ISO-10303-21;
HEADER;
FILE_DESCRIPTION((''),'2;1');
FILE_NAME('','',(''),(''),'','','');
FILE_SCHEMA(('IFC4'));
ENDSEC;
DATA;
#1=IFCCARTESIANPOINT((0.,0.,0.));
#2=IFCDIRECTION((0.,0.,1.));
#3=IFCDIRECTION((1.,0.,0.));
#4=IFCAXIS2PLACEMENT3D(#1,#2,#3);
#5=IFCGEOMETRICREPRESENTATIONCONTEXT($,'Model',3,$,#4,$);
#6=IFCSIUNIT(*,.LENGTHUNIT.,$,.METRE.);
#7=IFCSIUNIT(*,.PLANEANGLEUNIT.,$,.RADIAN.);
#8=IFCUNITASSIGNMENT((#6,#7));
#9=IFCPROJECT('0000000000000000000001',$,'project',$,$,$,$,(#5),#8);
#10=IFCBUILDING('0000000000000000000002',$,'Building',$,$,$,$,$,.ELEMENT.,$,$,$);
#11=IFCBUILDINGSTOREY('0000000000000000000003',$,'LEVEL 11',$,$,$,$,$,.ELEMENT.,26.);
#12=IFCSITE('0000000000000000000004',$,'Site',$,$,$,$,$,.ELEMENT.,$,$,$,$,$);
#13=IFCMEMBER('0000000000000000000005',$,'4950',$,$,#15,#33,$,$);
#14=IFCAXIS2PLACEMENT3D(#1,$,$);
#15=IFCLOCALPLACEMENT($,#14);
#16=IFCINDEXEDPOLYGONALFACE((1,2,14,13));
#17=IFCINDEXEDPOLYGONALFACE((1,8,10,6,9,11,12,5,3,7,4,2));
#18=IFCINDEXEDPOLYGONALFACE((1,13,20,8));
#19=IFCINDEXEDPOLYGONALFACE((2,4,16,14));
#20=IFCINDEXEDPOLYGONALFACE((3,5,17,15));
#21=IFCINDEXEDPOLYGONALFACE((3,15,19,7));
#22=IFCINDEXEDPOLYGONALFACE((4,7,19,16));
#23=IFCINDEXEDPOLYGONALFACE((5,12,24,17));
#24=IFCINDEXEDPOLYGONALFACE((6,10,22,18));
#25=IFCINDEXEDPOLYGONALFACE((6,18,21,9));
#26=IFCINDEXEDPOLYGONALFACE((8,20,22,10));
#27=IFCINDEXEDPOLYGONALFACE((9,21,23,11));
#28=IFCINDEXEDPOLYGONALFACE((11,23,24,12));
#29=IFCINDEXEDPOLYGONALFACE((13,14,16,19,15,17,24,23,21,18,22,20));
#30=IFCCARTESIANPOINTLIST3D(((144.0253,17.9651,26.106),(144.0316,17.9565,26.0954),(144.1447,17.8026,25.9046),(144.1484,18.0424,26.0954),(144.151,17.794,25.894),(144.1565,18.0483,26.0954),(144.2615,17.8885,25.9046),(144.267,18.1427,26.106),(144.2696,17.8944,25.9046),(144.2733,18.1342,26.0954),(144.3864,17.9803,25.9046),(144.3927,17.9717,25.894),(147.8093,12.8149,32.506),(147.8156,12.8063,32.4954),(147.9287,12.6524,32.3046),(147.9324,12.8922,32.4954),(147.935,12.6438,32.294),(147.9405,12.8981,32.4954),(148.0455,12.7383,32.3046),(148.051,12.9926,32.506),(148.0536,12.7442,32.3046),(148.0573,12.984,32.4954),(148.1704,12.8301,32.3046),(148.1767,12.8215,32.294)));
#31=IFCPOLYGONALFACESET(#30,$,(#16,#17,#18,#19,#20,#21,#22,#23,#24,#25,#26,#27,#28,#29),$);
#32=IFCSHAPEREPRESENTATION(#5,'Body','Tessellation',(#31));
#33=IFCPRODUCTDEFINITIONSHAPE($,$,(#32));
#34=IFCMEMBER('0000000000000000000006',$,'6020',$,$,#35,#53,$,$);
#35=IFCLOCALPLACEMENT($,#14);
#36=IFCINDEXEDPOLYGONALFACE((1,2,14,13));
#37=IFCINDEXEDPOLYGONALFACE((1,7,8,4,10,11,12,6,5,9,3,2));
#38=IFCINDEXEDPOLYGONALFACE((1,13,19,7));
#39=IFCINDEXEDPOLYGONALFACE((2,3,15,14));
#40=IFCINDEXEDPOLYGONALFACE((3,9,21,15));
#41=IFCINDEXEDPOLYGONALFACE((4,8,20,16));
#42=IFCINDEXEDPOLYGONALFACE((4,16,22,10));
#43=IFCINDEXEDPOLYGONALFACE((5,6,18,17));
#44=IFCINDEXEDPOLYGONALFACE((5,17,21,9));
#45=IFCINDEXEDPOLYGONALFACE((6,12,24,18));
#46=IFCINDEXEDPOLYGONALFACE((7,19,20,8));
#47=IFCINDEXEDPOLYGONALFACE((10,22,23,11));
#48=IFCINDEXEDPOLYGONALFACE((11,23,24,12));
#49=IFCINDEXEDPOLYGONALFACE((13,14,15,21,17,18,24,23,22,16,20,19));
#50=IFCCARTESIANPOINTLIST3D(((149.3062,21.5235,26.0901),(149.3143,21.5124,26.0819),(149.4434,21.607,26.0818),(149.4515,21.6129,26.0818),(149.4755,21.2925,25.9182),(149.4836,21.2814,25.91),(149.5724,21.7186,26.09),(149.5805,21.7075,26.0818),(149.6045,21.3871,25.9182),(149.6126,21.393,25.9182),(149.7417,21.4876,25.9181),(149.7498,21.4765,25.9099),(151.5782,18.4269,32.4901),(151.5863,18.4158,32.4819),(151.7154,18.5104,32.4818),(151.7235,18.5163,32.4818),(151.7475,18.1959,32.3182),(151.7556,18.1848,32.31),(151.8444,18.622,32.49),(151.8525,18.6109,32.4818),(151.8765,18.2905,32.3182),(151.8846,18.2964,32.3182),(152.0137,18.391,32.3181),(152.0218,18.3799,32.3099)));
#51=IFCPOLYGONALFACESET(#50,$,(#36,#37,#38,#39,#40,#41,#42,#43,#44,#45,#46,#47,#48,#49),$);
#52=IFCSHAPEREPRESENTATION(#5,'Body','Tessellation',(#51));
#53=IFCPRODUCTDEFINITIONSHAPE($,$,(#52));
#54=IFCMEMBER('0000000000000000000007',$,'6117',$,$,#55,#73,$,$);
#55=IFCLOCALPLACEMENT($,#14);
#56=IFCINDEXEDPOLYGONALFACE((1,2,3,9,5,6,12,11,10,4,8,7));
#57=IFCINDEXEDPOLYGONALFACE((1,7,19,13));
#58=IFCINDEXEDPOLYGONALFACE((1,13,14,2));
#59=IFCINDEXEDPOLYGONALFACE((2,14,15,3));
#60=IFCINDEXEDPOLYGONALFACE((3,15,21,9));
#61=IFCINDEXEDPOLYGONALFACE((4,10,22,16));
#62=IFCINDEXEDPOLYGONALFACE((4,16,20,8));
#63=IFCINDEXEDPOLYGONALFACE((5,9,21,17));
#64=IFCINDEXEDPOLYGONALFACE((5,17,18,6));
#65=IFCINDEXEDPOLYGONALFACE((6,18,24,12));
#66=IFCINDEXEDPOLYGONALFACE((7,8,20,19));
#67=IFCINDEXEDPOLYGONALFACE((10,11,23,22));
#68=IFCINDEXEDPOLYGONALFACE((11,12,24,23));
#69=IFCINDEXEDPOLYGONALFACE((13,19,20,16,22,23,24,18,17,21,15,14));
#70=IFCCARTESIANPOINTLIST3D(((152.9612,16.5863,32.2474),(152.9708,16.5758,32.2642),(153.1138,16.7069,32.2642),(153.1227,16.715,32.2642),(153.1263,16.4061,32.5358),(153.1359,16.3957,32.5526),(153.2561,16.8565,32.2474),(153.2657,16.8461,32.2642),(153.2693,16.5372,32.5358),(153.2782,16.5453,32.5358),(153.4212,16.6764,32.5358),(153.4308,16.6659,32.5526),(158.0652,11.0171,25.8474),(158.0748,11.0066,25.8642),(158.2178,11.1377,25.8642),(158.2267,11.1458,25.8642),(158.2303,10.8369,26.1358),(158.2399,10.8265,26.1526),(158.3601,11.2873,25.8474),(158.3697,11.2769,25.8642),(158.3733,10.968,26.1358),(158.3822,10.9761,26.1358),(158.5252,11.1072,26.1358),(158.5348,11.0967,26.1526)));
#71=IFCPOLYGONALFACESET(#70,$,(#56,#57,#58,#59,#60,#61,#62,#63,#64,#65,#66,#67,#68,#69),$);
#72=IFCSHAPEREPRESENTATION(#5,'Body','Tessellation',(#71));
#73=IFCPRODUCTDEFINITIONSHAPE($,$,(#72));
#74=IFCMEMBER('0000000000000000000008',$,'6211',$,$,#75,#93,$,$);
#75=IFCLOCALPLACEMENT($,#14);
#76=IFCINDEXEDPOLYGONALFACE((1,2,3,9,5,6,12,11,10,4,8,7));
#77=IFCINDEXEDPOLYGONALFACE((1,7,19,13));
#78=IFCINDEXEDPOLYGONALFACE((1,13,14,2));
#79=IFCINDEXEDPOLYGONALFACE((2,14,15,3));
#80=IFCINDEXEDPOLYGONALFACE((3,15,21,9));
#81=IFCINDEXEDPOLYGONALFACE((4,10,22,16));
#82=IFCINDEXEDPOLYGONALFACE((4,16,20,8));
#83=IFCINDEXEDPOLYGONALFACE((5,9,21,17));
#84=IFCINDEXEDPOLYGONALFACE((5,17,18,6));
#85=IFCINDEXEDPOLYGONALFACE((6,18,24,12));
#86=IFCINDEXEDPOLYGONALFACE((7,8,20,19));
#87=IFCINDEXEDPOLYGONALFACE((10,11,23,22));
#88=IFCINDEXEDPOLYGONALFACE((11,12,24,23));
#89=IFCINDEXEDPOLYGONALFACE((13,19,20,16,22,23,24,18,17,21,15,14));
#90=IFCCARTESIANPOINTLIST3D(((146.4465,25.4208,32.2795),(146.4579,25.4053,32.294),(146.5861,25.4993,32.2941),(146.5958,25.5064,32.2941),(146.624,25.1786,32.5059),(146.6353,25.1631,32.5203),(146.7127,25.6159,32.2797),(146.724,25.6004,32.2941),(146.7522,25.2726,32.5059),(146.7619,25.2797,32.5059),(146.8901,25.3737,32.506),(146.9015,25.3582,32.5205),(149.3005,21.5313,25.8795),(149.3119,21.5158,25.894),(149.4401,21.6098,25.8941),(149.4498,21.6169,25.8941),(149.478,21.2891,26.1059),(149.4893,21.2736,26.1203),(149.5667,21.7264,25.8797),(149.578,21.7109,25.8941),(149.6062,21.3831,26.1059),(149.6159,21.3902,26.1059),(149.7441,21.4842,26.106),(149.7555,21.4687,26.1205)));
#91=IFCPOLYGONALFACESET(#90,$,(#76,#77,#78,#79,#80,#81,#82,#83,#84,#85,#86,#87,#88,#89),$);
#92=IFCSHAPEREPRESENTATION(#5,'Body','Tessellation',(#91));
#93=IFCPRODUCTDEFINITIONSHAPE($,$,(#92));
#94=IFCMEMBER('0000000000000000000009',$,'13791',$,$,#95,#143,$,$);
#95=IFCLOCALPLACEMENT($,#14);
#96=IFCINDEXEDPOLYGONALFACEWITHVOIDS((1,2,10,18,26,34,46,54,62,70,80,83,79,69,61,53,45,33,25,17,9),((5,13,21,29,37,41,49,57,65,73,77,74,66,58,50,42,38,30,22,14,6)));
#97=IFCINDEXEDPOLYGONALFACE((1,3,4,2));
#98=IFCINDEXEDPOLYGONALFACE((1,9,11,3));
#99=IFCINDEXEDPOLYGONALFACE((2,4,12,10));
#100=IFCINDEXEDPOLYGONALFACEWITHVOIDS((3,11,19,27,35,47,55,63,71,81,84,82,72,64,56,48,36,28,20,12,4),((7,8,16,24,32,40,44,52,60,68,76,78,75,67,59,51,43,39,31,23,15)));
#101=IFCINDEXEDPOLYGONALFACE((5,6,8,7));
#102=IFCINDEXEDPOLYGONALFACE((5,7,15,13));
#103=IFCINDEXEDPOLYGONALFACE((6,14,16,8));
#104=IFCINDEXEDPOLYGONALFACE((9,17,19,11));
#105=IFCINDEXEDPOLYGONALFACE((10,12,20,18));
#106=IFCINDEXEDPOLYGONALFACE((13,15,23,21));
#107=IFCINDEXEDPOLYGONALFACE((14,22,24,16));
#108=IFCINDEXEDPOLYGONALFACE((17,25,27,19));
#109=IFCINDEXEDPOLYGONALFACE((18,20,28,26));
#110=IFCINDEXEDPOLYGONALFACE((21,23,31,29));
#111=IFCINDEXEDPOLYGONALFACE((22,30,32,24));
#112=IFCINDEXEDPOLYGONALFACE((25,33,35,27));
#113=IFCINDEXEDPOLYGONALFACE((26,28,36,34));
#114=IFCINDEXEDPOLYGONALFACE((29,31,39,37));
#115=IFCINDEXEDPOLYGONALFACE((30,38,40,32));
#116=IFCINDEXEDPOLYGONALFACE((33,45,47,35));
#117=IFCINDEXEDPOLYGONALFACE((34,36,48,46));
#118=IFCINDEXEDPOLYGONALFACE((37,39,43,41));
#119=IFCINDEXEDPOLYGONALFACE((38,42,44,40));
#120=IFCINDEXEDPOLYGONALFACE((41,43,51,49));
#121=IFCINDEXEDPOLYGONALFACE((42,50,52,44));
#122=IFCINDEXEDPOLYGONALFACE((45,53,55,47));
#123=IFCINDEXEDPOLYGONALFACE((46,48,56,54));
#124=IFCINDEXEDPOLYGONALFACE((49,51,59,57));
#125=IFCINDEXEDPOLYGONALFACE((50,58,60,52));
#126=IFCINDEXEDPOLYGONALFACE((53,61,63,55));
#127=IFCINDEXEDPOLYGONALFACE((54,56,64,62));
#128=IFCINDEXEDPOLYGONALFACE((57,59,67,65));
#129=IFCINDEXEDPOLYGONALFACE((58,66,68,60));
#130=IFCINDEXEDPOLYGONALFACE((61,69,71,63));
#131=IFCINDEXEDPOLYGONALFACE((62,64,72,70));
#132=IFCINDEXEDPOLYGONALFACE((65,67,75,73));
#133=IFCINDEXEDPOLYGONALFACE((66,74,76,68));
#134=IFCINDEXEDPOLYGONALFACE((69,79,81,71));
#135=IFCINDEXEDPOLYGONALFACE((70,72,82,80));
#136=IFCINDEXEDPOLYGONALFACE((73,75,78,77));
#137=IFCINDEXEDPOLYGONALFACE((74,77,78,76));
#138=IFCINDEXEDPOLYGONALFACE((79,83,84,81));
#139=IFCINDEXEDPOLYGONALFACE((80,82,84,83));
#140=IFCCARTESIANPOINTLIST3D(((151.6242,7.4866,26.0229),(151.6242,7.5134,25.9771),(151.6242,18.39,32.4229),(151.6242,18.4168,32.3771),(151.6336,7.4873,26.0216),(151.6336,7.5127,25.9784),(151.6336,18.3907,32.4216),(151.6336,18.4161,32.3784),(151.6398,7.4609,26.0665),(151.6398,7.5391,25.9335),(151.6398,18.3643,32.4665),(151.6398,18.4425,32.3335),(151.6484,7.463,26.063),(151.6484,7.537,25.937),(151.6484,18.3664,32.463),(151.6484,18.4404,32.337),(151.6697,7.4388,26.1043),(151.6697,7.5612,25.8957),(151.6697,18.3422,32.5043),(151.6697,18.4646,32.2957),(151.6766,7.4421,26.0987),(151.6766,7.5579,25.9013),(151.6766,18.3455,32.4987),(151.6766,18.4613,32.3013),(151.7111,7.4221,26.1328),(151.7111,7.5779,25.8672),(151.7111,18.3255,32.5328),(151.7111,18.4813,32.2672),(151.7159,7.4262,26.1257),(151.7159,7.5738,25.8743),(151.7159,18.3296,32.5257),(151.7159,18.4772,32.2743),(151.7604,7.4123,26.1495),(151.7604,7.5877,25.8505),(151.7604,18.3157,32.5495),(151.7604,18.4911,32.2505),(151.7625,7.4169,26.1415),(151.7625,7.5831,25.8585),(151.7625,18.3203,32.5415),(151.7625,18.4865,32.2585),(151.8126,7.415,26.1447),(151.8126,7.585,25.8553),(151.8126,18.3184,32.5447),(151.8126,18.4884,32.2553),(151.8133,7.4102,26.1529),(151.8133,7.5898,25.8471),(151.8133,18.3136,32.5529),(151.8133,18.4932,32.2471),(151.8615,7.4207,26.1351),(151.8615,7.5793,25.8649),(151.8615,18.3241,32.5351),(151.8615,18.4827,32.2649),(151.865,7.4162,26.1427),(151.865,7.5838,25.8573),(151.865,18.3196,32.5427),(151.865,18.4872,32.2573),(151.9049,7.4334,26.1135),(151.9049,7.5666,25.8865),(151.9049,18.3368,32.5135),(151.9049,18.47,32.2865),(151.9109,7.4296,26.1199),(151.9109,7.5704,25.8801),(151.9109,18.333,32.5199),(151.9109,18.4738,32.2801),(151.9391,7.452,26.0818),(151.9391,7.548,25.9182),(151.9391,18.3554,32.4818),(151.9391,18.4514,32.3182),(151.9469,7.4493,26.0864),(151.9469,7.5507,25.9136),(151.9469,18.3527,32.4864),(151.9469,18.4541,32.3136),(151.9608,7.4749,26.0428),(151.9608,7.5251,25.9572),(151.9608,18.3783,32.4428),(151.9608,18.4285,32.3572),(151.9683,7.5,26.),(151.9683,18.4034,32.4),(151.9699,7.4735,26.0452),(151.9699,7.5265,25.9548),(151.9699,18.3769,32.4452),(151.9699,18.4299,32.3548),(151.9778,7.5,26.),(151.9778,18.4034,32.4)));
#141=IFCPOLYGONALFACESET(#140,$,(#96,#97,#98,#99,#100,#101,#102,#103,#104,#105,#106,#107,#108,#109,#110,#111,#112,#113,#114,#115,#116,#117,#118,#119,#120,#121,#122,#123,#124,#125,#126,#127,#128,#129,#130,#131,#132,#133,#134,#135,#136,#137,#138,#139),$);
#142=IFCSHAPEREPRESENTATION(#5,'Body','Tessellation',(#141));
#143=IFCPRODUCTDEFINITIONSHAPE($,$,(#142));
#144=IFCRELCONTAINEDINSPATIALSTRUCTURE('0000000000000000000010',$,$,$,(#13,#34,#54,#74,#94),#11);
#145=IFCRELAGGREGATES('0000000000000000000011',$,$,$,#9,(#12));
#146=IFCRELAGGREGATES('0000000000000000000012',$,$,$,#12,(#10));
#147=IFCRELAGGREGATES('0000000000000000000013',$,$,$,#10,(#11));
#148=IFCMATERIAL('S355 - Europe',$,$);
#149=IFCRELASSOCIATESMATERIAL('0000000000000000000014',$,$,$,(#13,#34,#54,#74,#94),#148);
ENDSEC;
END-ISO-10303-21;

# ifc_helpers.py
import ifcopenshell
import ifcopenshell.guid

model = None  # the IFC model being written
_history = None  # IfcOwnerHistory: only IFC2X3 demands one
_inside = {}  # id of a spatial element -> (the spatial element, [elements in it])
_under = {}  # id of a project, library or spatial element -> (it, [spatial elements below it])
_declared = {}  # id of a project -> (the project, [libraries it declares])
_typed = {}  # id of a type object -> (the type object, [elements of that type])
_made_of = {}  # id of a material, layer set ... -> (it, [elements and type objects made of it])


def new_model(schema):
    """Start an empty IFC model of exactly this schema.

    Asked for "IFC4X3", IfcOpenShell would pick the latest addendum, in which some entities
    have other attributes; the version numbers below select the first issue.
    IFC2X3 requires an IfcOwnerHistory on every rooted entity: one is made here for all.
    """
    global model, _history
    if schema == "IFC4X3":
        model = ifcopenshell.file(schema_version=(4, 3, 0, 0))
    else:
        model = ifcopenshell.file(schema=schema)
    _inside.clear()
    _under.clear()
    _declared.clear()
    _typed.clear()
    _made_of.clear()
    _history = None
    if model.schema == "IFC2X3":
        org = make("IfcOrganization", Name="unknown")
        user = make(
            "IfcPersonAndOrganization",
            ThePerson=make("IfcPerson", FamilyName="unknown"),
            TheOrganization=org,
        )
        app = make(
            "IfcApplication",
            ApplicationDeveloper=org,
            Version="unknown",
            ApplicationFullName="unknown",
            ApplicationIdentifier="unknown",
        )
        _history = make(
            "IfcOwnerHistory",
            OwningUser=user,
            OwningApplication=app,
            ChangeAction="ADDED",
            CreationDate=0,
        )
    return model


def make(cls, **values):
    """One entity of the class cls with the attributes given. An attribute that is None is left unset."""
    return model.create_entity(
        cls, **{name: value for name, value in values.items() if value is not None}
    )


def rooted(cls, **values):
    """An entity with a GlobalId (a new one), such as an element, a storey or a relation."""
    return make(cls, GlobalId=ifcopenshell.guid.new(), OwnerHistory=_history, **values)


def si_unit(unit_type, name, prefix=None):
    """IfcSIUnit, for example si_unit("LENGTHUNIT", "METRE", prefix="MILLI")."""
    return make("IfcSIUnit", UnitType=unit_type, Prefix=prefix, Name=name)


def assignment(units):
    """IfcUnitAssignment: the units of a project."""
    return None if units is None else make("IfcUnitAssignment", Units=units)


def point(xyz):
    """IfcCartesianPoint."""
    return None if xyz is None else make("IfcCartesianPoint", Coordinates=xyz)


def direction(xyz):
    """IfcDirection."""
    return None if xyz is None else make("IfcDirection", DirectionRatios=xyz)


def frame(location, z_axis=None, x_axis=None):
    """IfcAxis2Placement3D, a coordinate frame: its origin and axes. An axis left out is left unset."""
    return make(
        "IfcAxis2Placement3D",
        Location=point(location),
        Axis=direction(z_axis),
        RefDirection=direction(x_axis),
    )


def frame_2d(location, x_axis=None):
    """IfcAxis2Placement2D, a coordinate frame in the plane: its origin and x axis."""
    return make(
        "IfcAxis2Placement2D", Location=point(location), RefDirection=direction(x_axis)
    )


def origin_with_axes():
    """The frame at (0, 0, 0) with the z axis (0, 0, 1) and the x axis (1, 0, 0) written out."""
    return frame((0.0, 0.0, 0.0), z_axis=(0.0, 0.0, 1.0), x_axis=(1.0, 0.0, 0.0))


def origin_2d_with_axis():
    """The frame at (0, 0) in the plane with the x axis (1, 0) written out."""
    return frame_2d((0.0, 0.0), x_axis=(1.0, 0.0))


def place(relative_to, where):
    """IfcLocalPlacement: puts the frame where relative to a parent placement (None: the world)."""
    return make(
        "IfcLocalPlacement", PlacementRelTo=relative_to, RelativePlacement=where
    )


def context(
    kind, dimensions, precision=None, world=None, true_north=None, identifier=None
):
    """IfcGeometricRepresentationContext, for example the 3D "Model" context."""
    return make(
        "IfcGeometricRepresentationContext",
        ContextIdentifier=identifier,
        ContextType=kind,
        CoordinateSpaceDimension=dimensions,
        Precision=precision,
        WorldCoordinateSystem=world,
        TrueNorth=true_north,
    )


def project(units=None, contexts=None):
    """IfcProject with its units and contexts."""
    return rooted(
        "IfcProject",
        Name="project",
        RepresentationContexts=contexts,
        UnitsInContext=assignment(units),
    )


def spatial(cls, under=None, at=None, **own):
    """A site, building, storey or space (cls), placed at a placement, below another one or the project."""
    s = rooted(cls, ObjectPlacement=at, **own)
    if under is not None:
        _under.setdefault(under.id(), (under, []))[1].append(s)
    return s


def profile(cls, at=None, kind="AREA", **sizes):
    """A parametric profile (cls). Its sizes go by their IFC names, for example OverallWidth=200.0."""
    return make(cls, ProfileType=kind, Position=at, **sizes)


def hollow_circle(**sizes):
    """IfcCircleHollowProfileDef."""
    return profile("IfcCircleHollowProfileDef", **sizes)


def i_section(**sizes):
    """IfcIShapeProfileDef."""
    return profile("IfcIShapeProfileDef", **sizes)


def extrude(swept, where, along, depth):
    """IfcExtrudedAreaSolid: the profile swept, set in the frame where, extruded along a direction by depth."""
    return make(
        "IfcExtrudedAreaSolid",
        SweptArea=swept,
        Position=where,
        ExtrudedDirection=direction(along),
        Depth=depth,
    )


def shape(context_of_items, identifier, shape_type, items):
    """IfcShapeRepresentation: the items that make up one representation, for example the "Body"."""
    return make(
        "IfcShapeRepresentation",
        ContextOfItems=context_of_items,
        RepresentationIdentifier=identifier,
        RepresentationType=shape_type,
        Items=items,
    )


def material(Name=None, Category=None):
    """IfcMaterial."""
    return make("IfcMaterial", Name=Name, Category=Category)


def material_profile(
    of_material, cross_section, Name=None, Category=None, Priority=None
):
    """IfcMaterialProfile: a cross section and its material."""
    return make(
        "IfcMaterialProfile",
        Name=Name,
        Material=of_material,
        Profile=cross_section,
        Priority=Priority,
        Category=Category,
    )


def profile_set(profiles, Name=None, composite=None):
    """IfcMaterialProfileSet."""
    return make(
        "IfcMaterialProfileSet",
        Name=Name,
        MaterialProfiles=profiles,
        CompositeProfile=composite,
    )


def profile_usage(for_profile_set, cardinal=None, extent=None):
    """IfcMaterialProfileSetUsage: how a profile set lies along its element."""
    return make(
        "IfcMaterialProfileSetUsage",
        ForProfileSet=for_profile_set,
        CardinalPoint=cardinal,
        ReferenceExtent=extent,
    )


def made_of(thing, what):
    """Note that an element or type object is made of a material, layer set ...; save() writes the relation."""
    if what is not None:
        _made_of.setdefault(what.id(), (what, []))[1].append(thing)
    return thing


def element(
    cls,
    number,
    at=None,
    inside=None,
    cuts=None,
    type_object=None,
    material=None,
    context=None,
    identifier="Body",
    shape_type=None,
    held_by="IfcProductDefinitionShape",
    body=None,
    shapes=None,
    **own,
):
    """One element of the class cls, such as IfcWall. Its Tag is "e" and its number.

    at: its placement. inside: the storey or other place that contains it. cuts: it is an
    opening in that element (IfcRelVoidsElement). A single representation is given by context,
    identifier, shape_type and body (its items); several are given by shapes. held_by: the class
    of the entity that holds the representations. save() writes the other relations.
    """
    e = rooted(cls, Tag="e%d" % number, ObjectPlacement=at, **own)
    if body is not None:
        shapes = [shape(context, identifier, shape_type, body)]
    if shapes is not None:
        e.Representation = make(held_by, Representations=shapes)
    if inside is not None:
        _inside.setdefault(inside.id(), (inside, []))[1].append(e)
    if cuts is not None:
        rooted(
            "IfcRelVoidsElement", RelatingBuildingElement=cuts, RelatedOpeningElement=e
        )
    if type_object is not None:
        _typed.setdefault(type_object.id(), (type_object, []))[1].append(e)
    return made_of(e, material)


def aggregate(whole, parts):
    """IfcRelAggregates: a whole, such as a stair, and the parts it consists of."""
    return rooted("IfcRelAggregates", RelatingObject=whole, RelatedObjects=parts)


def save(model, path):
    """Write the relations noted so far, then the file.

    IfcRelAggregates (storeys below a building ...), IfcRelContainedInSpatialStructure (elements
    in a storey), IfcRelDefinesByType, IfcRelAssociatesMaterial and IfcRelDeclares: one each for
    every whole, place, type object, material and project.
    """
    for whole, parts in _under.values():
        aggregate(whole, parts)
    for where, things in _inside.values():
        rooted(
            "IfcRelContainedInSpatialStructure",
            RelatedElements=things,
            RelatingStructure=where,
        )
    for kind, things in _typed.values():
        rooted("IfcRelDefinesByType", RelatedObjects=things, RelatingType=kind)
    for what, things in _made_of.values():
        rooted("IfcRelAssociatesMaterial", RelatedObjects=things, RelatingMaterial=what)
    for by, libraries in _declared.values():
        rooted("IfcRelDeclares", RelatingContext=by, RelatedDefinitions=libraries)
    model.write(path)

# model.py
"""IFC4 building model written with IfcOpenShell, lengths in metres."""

from ifc_helpers import new_model, si_unit, frame, origin_with_axes, origin_2d_with_axis, place, context, project, spatial, hollow_circle, i_section, extrude, material, material_profile, profile_set, profile_usage, element, save


model = new_model("IFC4")

# Units and contexts
model_context = context("Model", 3, world=origin_with_axes())
ifc_project = project(units=[si_unit("LENGTHUNIT", "METRE"), si_unit("PLANEANGLEUNIT", "RADIAN")], contexts=[model_context])

# Site, building, storey
site = spatial("IfcSite", under=ifc_project, Name="Site", CompositionType="ELEMENT")
building = spatial("IfcBuilding", under=site, Name="Building", CompositionType="ELEMENT")
storey = spatial("IfcBuildingStorey", under=building, Name="LEVEL 11", CompositionType="ELEMENT", Elevation=26.0)

# Shared definitions
ifc_material = material(Name="S355 - Europe")

# Members
ifc_material_profile_1 = material_profile(ifc_material, i_section(OverallWidth=0.3, OverallDepth=0.3, WebThickness=0.01, FlangeThickness=0.015, at=origin_2d_with_axis()))
ifc_profile_set_1 = profile_set([ifc_material_profile_1])
ifc_profile_usage_1 = profile_usage(ifc_profile_set_1, cardinal=10)
member_1_placement = place(None, frame((147.993, 12.8182, 32.4), z_axis=(-0.418375, 0.569428, -0.707611), x_axis=(-0.805765, -0.592235, 0.0)))
element("IfcMember", 1, at=member_1_placement, inside=storey, material=ifc_profile_usage_1, Name="4950", context=model_context, shape_type="SweptSolid", body=[
    extrude(i_section(OverallWidth=0.3, OverallDepth=0.3, WebThickness=0.01, FlangeThickness=0.015, at=origin_2d_with_axis()), origin_with_axes(), (0.0, 0.0, 1.0), 9.0445),
])
ifc_material_profile_2 = material_profile(ifc_material, i_section(OverallWidth=0.33, OverallDepth=0.35, WebThickness=0.01, FlangeThickness=0.016, at=origin_2d_with_axis()))
ifc_profile_set_2 = profile_set([ifc_material_profile_2])
ifc_profile_usage_2 = profile_usage(ifc_profile_set_2, cardinal=10)
member_2_placement = place(None, frame((151.8, 18.4034, 32.4), z_axis=(-0.304395, 0.414873, -0.857452), x_axis=(-0.806706, -0.590953, 0.0)))
element("IfcMember", 2, at=member_2_placement, inside=storey, material=ifc_profile_usage_2, Name="6020", context=model_context, shape_type="SweptSolid", body=[
    extrude(i_section(OverallWidth=0.33, OverallDepth=0.35, WebThickness=0.01, FlangeThickness=0.016, at=origin_2d_with_axis()), origin_with_axes(), (0.0, 0.0, 1.0), 7.464),
])
ifc_material_profile_3 = material_profile(ifc_material, i_section(OverallWidth=0.4, OverallDepth=0.4, WebThickness=0.012, FlangeThickness=0.022, at=origin_2d_with_axis()))
ifc_profile_set_3 = profile_set([ifc_material_profile_3])
ifc_profile_usage_3 = profile_usage(ifc_profile_set_3, cardinal=10)
member_3_placement = place(None, frame((158.3, 11.0569, 26.0), z_axis=(-0.515511, 0.562497, 0.646409), x_axis=(-0.737227, -0.675646, 0.0)))
element("IfcMember", 3, at=member_3_placement, inside=storey, material=ifc_profile_usage_3, Name="6117", context=model_context, shape_type="SweptSolid", body=[
    extrude(i_section(OverallWidth=0.4, OverallDepth=0.4, WebThickness=0.012, FlangeThickness=0.022, at=origin_2d_with_axis()), origin_with_axes(), (0.0, 0.0, 1.0), 9.9008),
])
ifc_material_profile_4 = material_profile(ifc_material, i_section(OverallWidth=0.33, OverallDepth=0.4, WebThickness=0.012, FlangeThickness=0.024, at=origin_2d_with_axis()))
ifc_profile_set_4 = profile_set([ifc_material_profile_4])
ifc_profile_usage_4 = profile_usage(ifc_profile_set_4, cardinal=10)
member_4_placement = place(None, frame((149.528, 21.5, 26.0), z_axis=(-0.356101, 0.485303, 0.798544), x_axis=(-0.806706, -0.590953, 0.0)))
element("IfcMember", 4, at=member_4_placement, inside=storey, material=ifc_profile_usage_4, Name="6211", context=model_context, shape_type="SweptSolid", body=[
    extrude(i_section(OverallWidth=0.33, OverallDepth=0.4, WebThickness=0.012, FlangeThickness=0.024, at=origin_2d_with_axis()), origin_with_axes(), (0.0, 0.0, 1.0), 8.0146),
])
ifc_material_profile_5 = material_profile(ifc_material, hollow_circle(Radius=0.1778, WallThickness=0.0095, at=origin_2d_with_axis()))
ifc_profile_set_5 = profile_set([ifc_material_profile_5])
ifc_profile_usage_5 = profile_usage(ifc_profile_set_5, cardinal=10)
member_5_placement = place(None, frame((151.8, 18.4034, 32.4), z_axis=(0.0, -0.86241, -0.506211), x_axis=(1.0, 0.0, 0.0)))
element("IfcMember", 5, at=member_5_placement, inside=storey, material=ifc_profile_usage_5, Name="13791", context=model_context, shape_type="SweptSolid", body=[
    extrude(hollow_circle(Radius=0.1778, WallThickness=0.0095, at=origin_2d_with_axis()), origin_with_axes(), (0.0, 0.0, 1.0), 12.6429),
])

save(model, "model.ifc")
